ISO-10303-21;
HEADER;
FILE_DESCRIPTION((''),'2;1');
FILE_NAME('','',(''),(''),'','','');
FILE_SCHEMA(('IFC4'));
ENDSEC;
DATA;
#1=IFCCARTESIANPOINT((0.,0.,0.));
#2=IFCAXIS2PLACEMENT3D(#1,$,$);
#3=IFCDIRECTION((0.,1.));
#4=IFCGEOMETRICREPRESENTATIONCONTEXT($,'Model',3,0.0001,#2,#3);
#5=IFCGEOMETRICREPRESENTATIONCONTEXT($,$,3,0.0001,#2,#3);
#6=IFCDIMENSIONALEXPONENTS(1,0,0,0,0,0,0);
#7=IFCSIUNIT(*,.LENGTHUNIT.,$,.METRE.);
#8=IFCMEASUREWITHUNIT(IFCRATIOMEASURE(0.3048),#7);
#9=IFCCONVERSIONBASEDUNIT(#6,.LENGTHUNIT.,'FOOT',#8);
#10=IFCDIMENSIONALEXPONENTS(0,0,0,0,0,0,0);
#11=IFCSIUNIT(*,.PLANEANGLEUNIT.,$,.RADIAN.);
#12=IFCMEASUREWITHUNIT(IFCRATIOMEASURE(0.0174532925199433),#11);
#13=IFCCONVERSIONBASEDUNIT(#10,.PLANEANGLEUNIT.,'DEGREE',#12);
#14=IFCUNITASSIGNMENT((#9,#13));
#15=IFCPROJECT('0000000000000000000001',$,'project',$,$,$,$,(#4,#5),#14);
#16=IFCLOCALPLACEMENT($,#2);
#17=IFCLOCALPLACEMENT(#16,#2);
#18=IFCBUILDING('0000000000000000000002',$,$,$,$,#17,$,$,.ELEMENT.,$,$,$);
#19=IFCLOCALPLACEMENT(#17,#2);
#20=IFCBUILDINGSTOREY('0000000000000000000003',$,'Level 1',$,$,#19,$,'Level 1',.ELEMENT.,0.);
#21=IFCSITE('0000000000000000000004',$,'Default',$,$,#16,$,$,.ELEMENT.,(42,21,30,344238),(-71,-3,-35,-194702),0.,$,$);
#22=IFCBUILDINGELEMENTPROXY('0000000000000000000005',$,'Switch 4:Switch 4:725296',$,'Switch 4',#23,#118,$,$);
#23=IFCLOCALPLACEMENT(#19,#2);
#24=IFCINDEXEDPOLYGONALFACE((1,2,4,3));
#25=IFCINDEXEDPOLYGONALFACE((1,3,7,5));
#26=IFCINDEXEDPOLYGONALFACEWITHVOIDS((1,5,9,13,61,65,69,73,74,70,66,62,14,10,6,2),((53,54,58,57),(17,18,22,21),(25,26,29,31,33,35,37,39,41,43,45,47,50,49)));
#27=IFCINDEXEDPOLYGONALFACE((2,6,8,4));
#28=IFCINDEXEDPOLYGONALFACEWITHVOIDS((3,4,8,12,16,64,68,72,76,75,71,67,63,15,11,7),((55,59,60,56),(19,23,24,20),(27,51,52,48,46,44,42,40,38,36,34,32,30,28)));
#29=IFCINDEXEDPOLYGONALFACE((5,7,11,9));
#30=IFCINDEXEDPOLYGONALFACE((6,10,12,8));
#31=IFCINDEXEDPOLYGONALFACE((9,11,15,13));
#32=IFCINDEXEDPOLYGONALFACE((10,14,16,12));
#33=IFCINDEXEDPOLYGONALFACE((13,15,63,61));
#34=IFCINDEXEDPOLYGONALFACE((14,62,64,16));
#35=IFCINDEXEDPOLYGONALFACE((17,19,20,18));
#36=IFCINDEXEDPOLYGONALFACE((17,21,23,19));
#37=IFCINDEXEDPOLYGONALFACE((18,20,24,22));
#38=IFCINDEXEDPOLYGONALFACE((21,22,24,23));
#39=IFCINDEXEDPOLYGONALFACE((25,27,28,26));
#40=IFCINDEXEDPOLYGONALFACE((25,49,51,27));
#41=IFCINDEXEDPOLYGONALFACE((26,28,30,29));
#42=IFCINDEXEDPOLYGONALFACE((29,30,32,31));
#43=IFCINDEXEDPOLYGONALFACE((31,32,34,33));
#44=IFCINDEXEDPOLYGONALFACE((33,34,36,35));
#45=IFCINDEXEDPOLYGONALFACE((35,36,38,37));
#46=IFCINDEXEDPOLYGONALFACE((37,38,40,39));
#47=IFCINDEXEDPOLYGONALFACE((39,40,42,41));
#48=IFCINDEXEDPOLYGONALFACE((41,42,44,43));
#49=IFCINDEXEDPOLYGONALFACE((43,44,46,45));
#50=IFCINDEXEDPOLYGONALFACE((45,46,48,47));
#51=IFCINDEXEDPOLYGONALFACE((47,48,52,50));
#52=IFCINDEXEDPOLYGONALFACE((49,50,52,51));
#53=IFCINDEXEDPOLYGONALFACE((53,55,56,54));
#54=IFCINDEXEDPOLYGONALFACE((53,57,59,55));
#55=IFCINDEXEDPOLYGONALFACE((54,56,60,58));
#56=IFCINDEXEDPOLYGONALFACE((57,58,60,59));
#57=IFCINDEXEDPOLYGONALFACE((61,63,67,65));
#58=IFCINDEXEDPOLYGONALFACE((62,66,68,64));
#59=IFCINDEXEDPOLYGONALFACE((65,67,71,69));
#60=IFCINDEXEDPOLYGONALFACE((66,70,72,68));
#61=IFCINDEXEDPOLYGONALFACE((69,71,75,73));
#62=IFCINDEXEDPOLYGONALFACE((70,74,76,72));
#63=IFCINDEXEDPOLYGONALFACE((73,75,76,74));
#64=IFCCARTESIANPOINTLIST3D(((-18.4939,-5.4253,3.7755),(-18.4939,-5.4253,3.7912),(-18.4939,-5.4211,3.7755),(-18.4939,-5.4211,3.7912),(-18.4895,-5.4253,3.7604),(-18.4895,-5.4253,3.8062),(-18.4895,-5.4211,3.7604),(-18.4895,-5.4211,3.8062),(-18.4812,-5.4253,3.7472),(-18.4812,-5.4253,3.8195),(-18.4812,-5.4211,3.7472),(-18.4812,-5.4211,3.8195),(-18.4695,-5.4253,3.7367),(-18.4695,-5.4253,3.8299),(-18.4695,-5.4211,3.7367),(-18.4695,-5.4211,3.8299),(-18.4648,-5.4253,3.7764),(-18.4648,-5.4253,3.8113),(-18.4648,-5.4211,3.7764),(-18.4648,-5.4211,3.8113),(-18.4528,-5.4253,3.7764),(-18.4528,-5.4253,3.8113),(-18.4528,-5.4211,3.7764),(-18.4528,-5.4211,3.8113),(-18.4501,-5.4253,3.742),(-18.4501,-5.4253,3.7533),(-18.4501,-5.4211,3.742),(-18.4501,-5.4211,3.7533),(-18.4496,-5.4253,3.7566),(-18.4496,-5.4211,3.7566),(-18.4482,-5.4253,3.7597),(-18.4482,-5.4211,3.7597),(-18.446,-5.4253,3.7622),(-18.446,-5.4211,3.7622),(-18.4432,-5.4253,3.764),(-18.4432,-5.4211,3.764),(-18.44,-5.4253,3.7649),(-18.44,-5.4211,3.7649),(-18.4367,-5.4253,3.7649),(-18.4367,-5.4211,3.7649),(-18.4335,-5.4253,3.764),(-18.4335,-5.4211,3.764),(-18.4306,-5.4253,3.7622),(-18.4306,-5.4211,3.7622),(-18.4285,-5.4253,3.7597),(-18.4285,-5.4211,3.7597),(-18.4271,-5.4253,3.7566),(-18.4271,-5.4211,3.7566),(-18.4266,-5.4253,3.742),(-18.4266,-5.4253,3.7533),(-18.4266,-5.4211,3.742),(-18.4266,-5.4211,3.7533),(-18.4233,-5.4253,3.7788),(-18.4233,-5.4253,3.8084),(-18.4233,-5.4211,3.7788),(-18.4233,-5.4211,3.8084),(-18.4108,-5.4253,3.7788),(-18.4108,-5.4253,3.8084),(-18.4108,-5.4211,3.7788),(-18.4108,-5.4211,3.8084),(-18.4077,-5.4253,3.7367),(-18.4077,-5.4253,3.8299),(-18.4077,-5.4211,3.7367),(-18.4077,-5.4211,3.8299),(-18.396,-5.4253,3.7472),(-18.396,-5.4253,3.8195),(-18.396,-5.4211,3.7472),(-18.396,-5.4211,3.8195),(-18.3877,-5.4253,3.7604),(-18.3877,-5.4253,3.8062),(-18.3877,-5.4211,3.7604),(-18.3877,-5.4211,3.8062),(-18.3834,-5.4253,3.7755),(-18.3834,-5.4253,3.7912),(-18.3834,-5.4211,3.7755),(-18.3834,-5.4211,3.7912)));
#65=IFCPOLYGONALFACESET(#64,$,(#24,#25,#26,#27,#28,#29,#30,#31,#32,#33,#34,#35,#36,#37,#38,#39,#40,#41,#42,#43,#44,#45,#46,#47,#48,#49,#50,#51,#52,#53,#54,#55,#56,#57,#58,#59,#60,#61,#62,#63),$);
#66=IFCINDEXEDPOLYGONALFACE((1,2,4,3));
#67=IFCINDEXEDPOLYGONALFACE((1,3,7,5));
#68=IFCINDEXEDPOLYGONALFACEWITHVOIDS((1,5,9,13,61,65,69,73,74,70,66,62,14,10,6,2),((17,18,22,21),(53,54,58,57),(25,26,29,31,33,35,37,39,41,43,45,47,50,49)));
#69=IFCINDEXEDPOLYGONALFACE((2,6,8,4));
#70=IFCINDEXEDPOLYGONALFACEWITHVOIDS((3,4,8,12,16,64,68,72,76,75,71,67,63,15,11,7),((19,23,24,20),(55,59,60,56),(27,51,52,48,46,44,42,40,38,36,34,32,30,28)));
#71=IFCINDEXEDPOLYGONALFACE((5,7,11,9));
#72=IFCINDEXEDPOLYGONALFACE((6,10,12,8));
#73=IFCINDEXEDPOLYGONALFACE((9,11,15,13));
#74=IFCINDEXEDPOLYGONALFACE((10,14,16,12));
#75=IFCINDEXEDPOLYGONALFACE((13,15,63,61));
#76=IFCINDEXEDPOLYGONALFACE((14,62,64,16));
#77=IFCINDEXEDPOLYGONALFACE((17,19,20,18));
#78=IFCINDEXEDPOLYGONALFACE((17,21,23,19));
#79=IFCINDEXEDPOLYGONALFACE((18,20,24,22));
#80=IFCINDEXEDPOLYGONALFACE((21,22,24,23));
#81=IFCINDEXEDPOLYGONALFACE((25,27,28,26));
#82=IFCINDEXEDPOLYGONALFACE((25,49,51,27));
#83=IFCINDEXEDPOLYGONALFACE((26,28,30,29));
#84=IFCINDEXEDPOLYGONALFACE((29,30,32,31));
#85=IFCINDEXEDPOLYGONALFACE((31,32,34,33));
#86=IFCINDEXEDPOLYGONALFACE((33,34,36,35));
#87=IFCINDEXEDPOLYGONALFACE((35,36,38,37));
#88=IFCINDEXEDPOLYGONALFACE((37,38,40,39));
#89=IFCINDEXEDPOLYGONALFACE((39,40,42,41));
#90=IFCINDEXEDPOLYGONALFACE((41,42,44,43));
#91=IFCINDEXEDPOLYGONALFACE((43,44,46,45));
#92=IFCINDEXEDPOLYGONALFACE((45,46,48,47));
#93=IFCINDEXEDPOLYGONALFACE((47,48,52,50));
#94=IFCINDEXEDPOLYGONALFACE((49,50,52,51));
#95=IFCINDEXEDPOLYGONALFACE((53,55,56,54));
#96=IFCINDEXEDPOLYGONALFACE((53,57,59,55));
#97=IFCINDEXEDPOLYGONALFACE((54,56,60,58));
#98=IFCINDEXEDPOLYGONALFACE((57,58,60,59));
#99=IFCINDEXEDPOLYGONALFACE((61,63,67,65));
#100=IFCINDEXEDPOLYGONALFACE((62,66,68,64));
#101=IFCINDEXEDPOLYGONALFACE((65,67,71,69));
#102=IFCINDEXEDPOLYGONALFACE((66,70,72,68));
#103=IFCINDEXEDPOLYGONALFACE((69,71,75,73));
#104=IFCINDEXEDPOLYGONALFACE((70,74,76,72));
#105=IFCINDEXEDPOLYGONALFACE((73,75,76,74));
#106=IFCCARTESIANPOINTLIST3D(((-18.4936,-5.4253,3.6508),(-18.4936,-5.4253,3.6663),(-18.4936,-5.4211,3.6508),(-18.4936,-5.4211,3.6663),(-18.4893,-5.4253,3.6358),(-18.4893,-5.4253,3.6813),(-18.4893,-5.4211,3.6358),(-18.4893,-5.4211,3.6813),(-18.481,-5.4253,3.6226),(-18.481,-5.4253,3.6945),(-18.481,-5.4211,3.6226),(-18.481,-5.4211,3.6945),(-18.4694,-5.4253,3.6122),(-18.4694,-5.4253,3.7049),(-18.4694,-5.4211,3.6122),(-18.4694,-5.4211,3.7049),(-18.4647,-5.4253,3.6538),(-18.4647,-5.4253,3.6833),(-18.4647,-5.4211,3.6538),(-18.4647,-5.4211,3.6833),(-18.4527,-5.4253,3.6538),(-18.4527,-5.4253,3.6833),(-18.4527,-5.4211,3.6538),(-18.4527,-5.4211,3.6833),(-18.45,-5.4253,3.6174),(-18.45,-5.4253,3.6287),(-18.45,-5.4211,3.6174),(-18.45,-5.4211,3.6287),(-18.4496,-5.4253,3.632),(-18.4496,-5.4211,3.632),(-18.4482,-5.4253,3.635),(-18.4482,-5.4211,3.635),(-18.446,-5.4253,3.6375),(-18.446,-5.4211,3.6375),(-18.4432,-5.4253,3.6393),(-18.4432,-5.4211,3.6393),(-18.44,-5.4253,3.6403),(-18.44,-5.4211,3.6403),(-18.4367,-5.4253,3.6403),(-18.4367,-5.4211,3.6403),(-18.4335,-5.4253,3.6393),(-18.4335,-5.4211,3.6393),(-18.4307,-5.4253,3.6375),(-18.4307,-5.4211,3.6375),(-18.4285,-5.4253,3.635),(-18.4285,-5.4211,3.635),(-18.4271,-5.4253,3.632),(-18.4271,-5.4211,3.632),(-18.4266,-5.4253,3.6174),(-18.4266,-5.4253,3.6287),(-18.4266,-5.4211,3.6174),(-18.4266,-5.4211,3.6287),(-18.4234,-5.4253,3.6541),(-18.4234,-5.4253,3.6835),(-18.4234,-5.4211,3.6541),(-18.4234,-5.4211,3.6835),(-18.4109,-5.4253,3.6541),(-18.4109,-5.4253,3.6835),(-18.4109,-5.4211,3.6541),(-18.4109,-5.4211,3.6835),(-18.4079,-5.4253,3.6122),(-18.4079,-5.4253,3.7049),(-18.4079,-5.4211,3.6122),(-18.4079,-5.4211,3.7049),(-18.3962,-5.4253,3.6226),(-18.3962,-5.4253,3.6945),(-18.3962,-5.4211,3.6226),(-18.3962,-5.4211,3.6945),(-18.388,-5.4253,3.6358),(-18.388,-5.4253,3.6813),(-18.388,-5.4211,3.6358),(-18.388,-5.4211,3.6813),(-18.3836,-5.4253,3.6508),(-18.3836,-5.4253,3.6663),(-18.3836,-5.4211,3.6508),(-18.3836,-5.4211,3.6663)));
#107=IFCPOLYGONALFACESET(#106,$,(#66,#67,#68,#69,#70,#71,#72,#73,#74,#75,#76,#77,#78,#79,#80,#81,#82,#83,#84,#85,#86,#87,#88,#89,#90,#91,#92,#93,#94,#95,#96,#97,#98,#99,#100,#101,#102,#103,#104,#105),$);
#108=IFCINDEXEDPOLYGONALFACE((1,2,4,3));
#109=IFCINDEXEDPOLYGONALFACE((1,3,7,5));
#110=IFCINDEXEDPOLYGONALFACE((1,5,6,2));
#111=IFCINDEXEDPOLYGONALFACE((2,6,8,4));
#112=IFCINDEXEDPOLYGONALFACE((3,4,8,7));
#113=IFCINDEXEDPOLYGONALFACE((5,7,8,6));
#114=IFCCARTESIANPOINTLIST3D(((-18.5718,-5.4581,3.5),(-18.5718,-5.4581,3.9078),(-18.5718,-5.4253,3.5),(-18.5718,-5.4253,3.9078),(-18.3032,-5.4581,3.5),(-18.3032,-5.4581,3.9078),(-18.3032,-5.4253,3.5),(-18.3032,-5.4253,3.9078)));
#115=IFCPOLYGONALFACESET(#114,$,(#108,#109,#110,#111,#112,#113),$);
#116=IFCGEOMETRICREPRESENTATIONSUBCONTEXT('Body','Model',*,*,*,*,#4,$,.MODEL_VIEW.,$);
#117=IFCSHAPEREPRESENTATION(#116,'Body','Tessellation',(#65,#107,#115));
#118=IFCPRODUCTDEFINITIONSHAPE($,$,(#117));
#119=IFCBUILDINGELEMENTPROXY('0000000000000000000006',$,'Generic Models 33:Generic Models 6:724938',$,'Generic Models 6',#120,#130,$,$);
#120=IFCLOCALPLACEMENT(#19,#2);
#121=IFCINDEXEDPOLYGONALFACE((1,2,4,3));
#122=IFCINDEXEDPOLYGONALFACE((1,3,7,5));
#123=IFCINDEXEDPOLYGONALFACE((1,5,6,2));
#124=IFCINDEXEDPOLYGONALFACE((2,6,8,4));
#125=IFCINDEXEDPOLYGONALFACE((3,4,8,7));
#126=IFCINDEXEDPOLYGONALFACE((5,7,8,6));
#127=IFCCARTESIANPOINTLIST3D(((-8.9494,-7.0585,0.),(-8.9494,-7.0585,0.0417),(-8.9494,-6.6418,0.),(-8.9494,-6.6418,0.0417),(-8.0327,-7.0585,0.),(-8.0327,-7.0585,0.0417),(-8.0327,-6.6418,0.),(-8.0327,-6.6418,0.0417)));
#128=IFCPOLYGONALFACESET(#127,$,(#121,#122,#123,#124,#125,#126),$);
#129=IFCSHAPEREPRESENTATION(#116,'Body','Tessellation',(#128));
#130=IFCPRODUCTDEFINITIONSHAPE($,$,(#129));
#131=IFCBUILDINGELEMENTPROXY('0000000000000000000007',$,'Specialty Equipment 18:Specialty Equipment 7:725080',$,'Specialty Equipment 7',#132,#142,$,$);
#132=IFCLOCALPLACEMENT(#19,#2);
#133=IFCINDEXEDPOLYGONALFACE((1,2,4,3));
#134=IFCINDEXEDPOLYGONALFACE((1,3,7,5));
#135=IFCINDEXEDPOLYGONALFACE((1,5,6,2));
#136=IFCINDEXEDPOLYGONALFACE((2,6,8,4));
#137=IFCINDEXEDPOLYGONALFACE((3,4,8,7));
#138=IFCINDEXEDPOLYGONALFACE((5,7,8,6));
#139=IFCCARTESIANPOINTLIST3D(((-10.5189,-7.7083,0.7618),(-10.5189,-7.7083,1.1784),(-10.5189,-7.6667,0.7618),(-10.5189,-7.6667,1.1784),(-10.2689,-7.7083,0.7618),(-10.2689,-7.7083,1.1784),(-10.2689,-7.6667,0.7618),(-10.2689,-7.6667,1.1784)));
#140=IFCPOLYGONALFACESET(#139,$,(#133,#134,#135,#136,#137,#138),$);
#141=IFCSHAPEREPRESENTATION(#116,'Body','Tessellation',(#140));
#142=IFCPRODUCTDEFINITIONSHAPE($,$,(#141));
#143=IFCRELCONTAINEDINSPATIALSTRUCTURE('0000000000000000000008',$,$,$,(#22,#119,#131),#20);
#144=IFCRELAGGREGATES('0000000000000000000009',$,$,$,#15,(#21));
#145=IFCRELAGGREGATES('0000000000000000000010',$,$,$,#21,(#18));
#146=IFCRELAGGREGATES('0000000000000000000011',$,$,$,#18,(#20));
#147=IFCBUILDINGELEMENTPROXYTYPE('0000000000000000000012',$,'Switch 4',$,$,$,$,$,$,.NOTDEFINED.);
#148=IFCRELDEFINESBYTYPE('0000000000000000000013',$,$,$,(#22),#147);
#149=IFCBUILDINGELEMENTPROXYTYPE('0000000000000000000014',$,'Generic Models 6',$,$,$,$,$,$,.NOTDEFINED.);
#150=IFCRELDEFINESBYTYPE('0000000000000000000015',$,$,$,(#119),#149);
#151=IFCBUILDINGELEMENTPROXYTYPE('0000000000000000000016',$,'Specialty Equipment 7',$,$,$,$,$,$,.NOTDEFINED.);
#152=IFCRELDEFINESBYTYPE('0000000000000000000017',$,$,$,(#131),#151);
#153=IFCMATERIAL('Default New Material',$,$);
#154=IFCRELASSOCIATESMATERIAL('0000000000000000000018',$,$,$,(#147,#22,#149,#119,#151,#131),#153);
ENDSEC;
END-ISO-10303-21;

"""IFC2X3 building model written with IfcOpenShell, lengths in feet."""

from ifc_helpers import new_model, entity, si_unit, converted_unit, direction, frame, frame_2d, origin, origin_2d_with_axis, place, context, subcontext, project, spatial, polyline, circle_curve, parameter, trimmed, segment, composite_curve, rectangle, outline, extrude, source, transform, mapped, material, type_object, type_shapes, element, save


model = new_model("IFC2X3")

# Units and contexts
model_context = context("Model", 3, precision=0.0001, world=origin(), true_north=direction((0.0, 1.0)))
context_of_model = context(None, 3, precision=0.0001, world=origin(), true_north=direction((0.0, 1.0)))
body_context = subcontext(model_context, "Body", "Model", "MODEL_VIEW")
ifc_project = project(units=[converted_unit("LENGTHUNIT", "FOOT", entity("IfcRatioMeasure", 0.3048), si_unit("LENGTHUNIT", "METRE"), dimensions=[1, 0, 0, 0, 0, 0, 0]), converted_unit("PLANEANGLEUNIT", "DEGREE", entity("IfcRatioMeasure", 0.0174532925199433), si_unit("PLANEANGLEUNIT", "RADIAN"), dimensions=[0, 0, 0, 0, 0, 0, 0])], contexts=[model_context, context_of_model])

# Site, building, storey
site_placement = place(None, origin())
site = spatial("IfcSite", under=ifc_project, at=site_placement, Name="Default", CompositionType="ELEMENT", RefLatitude=(42, 21, 30, 344238), RefLongitude=(-71, -3, -35, -194702), RefElevation=0.0)
building_placement = place(site_placement, origin())
building = spatial("IfcBuilding", under=site, at=building_placement, CompositionType="ELEMENT")
storey_placement = place(building_placement, origin())
storey = spatial("IfcBuildingStorey", under=building, at=storey_placement, Name="Level 1", LongName="Level 1", CompositionType="ELEMENT", Elevation=0.0)

# Shared definitions
ifc_material_1 = material(Name="Default New Material")

# Building element proxy
building_element_proxy_type_1 = type_object("IfcBuildingElementProxyType", Name="Switch 4", PredefinedType="NOTDEFINED", material=ifc_material_1)
shared_shape_1 = source(origin(), body_context, "Body", "SweptSolid", [
    extrude(outline(composite_curve([segment(polyline([(-0.0309, -0.0466), (0.0309, -0.0466)]), True, "CONTINUOUS"), segment(trimmed(circle_curve(frame_2d((-0.0003, 0.0), x_axis=(-1.0, 0.0)), 0.0561), [parameter(123.794741)], [parameter(236.205259)], True, "PARAMETER"), True, "CONTINUOUS"), segment(polyline([(0.0309, 0.0466), (-0.0309, 0.0466)]), True, "CONTINUOUS"), segment(trimmed(circle_curve(frame_2d((0.0003, 0.0), x_axis=(1.0, 0.0)), 0.0561), [parameter(123.794741)], [parameter(236.205259)], True, "PARAMETER"), True, "CONTINUOUS")], self_intersect=False), holes=[polyline([(0.0142, 0.0279), (0.0262, 0.0279), (0.0262, -0.0069), (0.0142, -0.0069), (0.0142, 0.0279)]), polyline([(-0.0153, 0.025), (-0.0153, -0.0045), (-0.0278, -0.0045), (-0.0278, 0.025), (-0.0153, 0.025)]), composite_curve([segment(polyline([(-0.012, -0.0413), (-0.012, -0.03)]), True, "CONTINUOUS"), segment(trimmed(circle_curve(frame_2d((-0.0003, -0.03), x_axis=(-1.0, 0.0)), 0.0117), [parameter(180.0)], [parameter(0.0)], True, "PARAMETER"), False, "CONTINUOUS"), segment(polyline([(0.0115, -0.03), (0.0115, -0.0413)]), True, "CONTINUOUS"), segment(polyline([(0.0115, -0.0413), (-0.012, -0.0413)]), True, "CONTINUOUS")], self_intersect=False)]), frame((-0.0011, 0.0328, 0.2833), z_axis=(0.0, 1.0, 0.0), x_axis=(-1.0, 0.0, 0.0)), (0.0, 0.0, 1.0), 0.0042),
    extrude(outline(composite_curve([segment(polyline([(-0.0308, -0.0464), (0.0308, -0.0464)]), True, "CONTINUOUS"), segment(trimmed(circle_curve(frame_2d((-0.0003, 0.0), x_axis=(-1.0, 0.0)), 0.0558), [parameter(123.794741)], [parameter(236.205259)], True, "PARAMETER"), True, "CONTINUOUS"), segment(polyline([(0.0308, 0.0464), (-0.0308, 0.0464)]), True, "CONTINUOUS"), segment(trimmed(circle_curve(frame_2d((0.0003, 0.0), x_axis=(1.0, 0.0)), 0.0558), [parameter(123.794741)], [parameter(236.205259)], True, "PARAMETER"), True, "CONTINUOUS")], self_intersect=False), holes=[polyline([(0.0141, 0.0247), (0.026, 0.0247), (0.026, -0.0047), (0.0141, -0.0047), (0.0141, 0.0247)]), polyline([(-0.0152, 0.0249), (-0.0152, -0.0045), (-0.0277, -0.0045), (-0.0277, 0.0249), (-0.0152, 0.0249)]), composite_curve([segment(polyline([(-0.012, -0.0411), (-0.012, -0.0299)]), True, "CONTINUOUS"), segment(trimmed(circle_curve(frame_2d((-0.0003, -0.0299), x_axis=(-1.0, 0.0)), 0.0117), [parameter(180.0)], [parameter(0.0)], True, "PARAMETER"), False, "CONTINUOUS"), segment(polyline([(0.0114, -0.0299), (0.0114, -0.0411)]), True, "CONTINUOUS"), segment(polyline([(0.0114, -0.0411), (-0.012, -0.0411)]), True, "CONTINUOUS")], self_intersect=False)]), frame((-0.0011, 0.0328, 0.1586), z_axis=(0.0, 1.0, 0.0), x_axis=(-1.0, 0.0, 0.0)), (0.0, 0.0, 1.0), 0.0042),
    extrude(rectangle(XDim=0.0328, YDim=0.2687, at=origin_2d_with_axis()), frame((0.0, 0.0164, 0.0), z_axis=(0.0, 0.0, 1.0), x_axis=(0.0, -1.0, 0.0)), (0.0, 0.0, 1.0), 0.4078),
])
type_shapes(building_element_proxy_type_1, [shared_shape_1])
proxy_1_placement = place(storey_placement, frame((-18.4375, -5.4581, 3.5)))
element("IfcBuildingElementProxy", 1, at=proxy_1_placement, inside=storey, type_object=building_element_proxy_type_1, material=ifc_material_1, Name="Switch 4:Switch 4:725296", ObjectType="Switch 4", context=body_context, shape_type="MappedRepresentation", body=[
    mapped(shared_shape_1, transform((0.0, 0.0, 0.0), scale=1.0)),
])

# Building element proxies
building_element_proxy_type_2 = type_object("IfcBuildingElementProxyType", Name="Generic Models 6", PredefinedType="NOTDEFINED", material=ifc_material_1)
shared_shape_2 = source(origin(), body_context, "Body", "SweptSolid", [
    extrude(rectangle(XDim=0.9167, YDim=0.4167, at=frame_2d((0.0, 0.0), x_axis=(1.0, 0.0))), frame((0.4583, 0.2083, 0.0), z_axis=(0.0, 0.0, 1.0), x_axis=(-1.0, 0.0, 0.0)), (0.0, 0.0, 1.0), 0.0417),
])
type_shapes(building_element_proxy_type_2, [shared_shape_2])
proxy_2_placement = place(storey_placement, frame((-8.9494, -7.0585, 0.0)))
element("IfcBuildingElementProxy", 2, at=proxy_2_placement, inside=storey, type_object=building_element_proxy_type_2, material=ifc_material_1, Name="Generic Models 33:Generic Models 6:724938", ObjectType="Generic Models 6", context=body_context, shape_type="MappedRepresentation", body=[
    mapped(shared_shape_2, transform((0.0, 0.0, 0.0), scale=1.0)),
])
building_element_proxy_type_3 = type_object("IfcBuildingElementProxyType", Name="Specialty Equipment 7", PredefinedType="NOTDEFINED", material=ifc_material_1)
shared_shape_3 = source(origin(), body_context, "Body", "SweptSolid", [
    extrude(rectangle(XDim=0.0417, YDim=0.25, at=frame_2d((0.0, 0.0), x_axis=(1.0, 0.0))), frame((0.125, 0.0208, 0.0), z_axis=(0.0, 0.0, 1.0), x_axis=(0.0, 1.0, 0.0)), (0.0, 0.0, 1.0), 0.4167),
])
type_shapes(building_element_proxy_type_3, [shared_shape_3])
proxy_3_placement = place(storey_placement, frame((-10.5189, -7.7083, 0.7618)))
element("IfcBuildingElementProxy", 3, at=proxy_3_placement, inside=storey, type_object=building_element_proxy_type_3, material=ifc_material_1, Name="Specialty Equipment 18:Specialty Equipment 7:725080", ObjectType="Specialty Equipment 7", context=body_context, shape_type="MappedRepresentation", body=[
    mapped(shared_shape_3, transform((0.0, 0.0, 0.0), scale=1.0)),
])

save(model, "model.ifc")
